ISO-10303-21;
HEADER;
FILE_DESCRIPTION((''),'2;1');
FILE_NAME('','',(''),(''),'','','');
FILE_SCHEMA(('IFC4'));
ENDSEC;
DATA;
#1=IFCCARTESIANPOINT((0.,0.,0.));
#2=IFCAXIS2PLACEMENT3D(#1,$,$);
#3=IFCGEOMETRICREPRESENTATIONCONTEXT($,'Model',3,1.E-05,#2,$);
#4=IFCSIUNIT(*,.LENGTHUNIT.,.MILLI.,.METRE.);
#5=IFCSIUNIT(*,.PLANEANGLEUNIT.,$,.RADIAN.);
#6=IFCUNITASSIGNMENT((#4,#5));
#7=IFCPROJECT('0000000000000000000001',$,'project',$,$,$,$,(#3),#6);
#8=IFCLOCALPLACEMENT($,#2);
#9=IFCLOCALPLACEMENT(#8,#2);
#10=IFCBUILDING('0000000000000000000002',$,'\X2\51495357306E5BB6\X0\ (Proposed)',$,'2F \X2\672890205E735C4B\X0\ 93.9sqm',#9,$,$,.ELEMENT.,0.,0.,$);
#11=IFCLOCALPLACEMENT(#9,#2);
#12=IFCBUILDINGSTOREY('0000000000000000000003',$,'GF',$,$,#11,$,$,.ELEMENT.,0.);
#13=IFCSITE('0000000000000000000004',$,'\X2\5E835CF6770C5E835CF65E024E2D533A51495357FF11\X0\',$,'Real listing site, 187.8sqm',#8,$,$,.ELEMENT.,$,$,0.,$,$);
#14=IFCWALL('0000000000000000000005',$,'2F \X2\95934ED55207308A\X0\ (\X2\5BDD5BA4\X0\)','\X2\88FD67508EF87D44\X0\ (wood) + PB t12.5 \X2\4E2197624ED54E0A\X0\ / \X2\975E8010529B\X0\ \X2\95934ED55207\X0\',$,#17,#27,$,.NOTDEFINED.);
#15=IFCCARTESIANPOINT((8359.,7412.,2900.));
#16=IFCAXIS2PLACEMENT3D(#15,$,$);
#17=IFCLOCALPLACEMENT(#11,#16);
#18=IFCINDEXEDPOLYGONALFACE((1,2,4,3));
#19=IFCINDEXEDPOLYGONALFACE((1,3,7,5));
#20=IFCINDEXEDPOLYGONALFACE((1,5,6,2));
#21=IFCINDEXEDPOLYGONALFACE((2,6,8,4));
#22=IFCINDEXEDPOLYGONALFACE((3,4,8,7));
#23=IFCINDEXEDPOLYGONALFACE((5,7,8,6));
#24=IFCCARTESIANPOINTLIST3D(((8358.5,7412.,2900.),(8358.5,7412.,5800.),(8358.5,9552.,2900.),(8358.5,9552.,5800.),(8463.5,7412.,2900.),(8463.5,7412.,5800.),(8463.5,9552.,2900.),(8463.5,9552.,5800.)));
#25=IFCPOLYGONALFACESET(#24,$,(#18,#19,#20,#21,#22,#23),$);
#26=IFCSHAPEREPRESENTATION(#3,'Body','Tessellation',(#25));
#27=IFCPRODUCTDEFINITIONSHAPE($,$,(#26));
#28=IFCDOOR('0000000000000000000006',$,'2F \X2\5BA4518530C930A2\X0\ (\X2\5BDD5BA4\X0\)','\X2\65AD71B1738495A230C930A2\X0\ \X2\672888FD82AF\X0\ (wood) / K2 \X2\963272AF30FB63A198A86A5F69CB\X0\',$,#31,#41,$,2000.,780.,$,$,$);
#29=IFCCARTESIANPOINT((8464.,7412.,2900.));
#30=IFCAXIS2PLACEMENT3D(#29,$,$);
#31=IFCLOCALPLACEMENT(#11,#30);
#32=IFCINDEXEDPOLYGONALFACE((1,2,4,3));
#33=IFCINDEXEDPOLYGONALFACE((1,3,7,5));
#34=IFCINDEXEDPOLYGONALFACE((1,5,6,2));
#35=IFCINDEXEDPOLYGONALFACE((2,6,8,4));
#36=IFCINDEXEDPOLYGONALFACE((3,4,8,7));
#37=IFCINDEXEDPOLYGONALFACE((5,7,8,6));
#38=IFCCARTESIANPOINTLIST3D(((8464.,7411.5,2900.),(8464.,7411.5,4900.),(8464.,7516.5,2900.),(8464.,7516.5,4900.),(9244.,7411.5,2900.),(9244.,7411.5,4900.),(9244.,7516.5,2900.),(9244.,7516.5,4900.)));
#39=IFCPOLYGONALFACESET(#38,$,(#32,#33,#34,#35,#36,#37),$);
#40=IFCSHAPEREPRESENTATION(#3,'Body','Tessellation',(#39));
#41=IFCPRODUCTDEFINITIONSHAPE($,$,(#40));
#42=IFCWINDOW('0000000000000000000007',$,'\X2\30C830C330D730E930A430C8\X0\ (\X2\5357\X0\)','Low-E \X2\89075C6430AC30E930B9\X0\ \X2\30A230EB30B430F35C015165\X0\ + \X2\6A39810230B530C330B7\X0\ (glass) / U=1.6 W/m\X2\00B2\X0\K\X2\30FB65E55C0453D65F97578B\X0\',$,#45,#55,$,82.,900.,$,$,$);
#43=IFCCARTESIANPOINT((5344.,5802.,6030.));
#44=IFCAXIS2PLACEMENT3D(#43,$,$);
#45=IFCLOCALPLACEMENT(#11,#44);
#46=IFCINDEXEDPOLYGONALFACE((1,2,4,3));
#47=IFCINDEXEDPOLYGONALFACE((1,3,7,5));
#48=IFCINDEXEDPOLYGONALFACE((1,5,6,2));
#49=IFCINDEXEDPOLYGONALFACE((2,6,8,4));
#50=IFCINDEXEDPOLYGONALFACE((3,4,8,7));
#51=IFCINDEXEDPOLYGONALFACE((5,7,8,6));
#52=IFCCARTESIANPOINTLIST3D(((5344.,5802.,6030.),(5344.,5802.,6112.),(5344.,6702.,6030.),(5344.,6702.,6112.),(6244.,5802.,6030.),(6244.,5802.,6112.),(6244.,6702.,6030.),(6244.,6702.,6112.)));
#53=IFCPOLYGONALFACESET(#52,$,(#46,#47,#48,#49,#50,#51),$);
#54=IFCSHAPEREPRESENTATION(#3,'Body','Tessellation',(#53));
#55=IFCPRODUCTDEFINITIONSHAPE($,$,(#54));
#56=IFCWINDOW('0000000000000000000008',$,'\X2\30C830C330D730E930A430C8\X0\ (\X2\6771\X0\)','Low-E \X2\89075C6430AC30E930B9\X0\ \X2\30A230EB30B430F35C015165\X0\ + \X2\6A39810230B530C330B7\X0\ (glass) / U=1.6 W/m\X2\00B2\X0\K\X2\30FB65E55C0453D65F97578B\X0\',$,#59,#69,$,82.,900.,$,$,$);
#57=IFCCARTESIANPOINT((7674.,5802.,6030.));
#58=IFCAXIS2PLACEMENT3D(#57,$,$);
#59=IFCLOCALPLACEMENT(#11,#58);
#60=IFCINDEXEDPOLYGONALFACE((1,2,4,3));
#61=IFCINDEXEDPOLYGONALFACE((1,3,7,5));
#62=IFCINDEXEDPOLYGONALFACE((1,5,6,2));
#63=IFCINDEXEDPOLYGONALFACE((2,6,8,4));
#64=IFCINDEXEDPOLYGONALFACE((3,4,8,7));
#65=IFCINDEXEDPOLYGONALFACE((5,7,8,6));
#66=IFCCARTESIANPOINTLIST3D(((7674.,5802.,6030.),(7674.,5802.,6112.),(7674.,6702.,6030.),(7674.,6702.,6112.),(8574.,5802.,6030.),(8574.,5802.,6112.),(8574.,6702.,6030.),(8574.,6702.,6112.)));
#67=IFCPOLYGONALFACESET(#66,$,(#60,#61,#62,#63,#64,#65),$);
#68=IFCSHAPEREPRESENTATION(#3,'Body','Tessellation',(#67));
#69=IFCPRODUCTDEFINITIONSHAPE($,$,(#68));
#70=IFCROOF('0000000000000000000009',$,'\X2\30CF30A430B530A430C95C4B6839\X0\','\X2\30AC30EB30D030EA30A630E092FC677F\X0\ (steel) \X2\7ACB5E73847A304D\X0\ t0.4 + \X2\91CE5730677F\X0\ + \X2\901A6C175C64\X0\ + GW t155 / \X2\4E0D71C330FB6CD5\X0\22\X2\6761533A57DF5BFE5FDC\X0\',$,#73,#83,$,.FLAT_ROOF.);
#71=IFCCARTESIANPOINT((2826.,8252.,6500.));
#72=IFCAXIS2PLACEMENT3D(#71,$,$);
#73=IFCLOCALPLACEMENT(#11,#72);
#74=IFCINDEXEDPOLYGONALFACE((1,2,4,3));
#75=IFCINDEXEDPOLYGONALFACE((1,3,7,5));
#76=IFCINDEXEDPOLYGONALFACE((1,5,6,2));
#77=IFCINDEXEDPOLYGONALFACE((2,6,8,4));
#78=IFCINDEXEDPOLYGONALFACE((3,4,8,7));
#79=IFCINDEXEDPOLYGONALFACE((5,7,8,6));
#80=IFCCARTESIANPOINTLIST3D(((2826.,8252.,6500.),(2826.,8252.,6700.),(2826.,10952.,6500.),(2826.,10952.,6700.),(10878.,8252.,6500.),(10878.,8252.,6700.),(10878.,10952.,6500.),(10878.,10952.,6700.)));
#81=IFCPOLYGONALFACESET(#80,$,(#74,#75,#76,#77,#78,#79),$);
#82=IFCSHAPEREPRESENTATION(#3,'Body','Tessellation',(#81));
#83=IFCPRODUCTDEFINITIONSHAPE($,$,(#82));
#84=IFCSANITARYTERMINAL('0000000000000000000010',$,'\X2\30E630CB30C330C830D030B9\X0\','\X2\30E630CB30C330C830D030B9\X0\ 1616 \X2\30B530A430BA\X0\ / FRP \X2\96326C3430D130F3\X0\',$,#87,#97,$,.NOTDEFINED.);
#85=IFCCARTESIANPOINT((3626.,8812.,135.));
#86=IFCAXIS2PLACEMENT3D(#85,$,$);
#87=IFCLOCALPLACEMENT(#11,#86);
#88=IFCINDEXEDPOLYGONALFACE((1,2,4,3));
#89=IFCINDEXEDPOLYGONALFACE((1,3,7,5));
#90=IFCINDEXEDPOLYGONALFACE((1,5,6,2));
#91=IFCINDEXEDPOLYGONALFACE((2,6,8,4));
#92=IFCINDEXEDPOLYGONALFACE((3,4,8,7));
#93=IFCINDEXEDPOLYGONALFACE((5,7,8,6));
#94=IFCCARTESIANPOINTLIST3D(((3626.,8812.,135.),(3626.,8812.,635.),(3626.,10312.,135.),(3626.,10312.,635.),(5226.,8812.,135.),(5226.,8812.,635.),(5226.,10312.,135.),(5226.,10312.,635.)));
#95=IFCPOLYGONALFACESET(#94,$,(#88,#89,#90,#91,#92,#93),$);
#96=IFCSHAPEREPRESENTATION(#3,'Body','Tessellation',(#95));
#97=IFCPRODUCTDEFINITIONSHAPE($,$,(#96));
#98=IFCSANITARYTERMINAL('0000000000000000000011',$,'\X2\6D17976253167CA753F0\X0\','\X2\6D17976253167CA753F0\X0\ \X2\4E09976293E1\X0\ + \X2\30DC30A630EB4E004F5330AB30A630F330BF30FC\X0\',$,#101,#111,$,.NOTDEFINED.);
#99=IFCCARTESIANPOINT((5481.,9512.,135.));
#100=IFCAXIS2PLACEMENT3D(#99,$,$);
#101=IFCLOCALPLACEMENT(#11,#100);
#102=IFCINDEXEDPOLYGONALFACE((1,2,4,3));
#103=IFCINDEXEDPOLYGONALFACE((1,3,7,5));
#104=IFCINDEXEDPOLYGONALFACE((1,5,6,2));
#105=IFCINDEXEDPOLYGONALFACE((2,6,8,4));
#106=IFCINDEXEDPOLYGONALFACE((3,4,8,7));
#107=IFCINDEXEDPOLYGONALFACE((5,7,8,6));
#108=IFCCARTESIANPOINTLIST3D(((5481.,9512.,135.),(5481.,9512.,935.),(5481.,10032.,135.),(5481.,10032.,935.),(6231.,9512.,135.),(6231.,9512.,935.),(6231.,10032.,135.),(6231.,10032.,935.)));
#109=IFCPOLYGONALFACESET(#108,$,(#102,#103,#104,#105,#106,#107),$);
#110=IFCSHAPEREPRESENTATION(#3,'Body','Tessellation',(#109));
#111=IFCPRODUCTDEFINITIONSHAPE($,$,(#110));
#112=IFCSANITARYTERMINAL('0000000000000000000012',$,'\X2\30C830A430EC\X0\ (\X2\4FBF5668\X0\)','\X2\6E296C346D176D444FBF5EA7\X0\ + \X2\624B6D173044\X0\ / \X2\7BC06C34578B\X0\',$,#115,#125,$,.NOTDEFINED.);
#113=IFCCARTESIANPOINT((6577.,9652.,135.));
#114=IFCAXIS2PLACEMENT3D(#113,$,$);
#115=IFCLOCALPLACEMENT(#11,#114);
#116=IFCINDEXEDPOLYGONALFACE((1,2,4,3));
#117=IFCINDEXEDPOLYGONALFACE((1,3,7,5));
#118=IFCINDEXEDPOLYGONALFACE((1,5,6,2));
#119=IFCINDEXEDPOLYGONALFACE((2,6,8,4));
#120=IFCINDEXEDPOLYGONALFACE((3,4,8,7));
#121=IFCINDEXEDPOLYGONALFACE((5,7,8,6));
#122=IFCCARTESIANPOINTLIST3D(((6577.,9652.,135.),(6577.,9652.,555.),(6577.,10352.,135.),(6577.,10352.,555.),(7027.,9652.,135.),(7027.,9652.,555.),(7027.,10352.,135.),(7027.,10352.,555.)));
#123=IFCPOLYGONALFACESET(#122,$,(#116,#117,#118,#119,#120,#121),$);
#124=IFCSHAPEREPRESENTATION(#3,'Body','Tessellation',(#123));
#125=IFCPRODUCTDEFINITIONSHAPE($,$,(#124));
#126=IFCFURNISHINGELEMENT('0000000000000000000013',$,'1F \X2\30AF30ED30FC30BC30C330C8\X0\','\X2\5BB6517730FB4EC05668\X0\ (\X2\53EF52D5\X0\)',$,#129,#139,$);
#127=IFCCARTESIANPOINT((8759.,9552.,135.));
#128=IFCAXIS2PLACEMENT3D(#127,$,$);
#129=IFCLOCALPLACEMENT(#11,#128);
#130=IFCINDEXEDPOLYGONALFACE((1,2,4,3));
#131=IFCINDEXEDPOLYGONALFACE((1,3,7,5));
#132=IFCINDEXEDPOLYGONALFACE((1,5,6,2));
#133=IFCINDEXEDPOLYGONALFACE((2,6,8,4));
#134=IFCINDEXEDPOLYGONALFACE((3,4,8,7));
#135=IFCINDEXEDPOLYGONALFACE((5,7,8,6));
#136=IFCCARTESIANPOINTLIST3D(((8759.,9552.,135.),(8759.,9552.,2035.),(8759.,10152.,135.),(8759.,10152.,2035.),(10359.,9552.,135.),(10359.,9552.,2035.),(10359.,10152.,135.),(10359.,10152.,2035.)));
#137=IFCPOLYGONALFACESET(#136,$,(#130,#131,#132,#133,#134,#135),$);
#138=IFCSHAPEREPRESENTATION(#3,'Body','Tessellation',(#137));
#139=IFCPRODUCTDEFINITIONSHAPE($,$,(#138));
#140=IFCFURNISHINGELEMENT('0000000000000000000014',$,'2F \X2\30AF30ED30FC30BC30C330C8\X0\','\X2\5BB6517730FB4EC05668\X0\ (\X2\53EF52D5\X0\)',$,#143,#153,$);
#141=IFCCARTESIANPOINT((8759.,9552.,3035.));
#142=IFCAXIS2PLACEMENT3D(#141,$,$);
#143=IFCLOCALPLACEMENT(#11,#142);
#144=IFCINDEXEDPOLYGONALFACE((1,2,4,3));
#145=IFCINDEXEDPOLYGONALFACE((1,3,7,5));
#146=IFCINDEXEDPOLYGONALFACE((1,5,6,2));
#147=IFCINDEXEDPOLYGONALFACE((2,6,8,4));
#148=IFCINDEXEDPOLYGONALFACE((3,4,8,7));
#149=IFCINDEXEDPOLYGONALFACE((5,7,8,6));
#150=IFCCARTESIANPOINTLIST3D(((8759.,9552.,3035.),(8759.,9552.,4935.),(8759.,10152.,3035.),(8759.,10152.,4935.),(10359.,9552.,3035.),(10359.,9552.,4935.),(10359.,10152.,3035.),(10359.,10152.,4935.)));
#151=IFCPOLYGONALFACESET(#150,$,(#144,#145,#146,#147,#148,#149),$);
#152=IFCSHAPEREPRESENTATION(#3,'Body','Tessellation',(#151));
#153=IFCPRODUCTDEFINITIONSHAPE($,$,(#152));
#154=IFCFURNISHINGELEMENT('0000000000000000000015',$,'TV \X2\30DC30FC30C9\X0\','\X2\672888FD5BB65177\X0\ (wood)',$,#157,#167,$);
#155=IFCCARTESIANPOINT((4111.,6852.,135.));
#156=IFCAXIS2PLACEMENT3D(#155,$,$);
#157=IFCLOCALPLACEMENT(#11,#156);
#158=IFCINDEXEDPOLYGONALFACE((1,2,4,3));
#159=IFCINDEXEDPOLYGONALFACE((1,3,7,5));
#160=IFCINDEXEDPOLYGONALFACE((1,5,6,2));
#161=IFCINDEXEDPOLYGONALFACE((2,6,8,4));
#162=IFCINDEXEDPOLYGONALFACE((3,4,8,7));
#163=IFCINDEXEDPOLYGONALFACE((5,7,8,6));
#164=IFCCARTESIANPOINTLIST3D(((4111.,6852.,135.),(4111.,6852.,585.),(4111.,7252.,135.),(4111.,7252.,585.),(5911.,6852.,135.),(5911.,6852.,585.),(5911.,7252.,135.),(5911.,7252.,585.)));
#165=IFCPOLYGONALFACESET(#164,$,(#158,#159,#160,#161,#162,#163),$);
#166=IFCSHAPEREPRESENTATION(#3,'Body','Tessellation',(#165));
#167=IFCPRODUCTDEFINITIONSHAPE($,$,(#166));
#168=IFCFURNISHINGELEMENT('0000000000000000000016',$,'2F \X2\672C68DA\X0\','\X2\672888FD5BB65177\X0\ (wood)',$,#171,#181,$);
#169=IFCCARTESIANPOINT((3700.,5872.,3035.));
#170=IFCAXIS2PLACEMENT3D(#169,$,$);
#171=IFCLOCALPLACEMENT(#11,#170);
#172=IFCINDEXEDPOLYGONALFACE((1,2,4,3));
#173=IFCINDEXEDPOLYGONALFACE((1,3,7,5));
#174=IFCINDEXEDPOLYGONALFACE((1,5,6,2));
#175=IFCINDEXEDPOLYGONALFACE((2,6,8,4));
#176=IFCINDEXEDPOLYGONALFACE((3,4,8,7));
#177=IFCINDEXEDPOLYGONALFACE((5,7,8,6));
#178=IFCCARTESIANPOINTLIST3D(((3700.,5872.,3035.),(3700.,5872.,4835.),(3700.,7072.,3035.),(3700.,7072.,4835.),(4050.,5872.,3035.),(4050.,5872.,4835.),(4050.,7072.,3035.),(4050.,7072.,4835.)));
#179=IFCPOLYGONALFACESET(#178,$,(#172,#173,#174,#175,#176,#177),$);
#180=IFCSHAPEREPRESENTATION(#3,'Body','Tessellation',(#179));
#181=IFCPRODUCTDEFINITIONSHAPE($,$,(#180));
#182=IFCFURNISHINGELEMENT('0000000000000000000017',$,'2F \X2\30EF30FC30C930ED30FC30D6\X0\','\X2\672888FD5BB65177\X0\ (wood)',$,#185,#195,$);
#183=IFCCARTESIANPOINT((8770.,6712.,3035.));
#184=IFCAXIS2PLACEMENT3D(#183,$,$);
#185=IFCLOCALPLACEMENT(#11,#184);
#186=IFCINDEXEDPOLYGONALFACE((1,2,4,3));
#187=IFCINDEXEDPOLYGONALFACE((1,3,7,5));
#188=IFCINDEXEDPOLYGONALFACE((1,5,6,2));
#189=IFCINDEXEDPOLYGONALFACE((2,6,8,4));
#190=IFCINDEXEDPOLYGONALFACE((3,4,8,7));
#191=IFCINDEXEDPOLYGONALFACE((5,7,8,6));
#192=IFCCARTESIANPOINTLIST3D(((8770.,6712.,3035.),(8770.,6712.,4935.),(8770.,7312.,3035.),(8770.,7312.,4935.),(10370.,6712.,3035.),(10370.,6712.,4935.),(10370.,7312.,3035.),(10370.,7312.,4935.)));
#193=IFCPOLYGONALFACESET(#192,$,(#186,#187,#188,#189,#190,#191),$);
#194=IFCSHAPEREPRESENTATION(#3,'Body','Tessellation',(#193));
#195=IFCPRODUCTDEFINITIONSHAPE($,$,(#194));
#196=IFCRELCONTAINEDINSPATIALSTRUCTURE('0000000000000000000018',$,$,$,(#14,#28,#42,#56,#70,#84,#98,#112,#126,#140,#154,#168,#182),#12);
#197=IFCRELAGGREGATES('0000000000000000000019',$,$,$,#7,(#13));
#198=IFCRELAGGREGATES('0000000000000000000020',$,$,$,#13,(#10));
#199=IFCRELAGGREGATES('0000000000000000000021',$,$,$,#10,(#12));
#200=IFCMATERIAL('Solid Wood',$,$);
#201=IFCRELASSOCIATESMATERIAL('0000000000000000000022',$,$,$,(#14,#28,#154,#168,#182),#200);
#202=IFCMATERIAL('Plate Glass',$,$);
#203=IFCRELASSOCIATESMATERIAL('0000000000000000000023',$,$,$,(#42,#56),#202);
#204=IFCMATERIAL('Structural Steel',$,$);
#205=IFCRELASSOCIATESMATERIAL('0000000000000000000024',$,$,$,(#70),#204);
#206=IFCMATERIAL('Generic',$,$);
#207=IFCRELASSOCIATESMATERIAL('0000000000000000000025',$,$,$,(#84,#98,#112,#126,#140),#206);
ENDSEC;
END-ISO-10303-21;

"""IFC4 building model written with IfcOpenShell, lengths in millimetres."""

from ifc_helpers import new_model, si_unit, frame, frame_2d, origin, place, context, project, spatial, rectangle, extrude, material, element, save


model = new_model("IFC4")

# Units and contexts
model_context = context("Model", 3, precision=1e-05, world=origin())
ifc_project = project(units=[si_unit("LENGTHUNIT", "METRE", prefix="MILLI"), si_unit("PLANEANGLEUNIT", "RADIAN")], contexts=[model_context])

# Site, building, storey
site_placement = place(None, origin())
site = spatial("IfcSite", under=ifc_project, at=site_placement, Name="広島県広島市中区光南１", ObjectType="Real listing site, 187.8sqm", CompositionType="ELEMENT", RefElevation=0.0)
building_placement = place(site_placement, origin())
building = spatial("IfcBuilding", under=site, at=building_placement, Name="光南の家 (Proposed)", ObjectType="2F 木造平屋 93.9sqm", CompositionType="ELEMENT", ElevationOfRefHeight=0.0, ElevationOfTerrain=0.0)
storey_placement = place(building_placement, origin())
storey = spatial("IfcBuildingStorey", under=building, at=storey_placement, Name="GF", CompositionType="ELEMENT", Elevation=0.0)

# Shared definitions
ifc_material_1 = material(Name="Solid Wood")
ifc_material_2 = material(Name="Plate Glass")

# Wall
wall_1_placement = place(storey_placement, frame((8359.0, 7412.0, 2900.0)))
element("IfcWall", 1, at=wall_1_placement, inside=storey, material=ifc_material_1, Name="2F 間仕切り (寝室)", Description="製材軸組 (wood) + PB t12.5 両面仕上 / 非耐力 間仕切", PredefinedType="NOTDEFINED", context=model_context, shape_type="SweptSolid", body=[
    extrude(rectangle(XDim=105.0, YDim=2140.0, at=frame_2d((52.0, 1070.0))), frame((8359.0, 7412.0, 2900.0)), (0.0, 0.0, 1.0), 2900.0),
])

# Door
door_1_placement = place(storey_placement, frame((8464.0, 7412.0, 2900.0)))
element("IfcDoor", 2, at=door_1_placement, inside=storey, material=ifc_material_1, Name="2F 室内ドア (寝室)", Description="断熱玄関ドア 木製芯 (wood) / K2 防犯・採風機構", OverallHeight=2000.0, OverallWidth=780.0, context=model_context, shape_type="SweptSolid", body=[
    extrude(rectangle(XDim=780.0, YDim=105.0, at=frame_2d((390.0, 52.0))), frame((8464.0, 7412.0, 2900.0)), (0.0, 0.0, 1.0), 2000.0),
])

# Windows
window_1_placement = place(storey_placement, frame((5344.0, 5802.0, 6030.0)))
element("IfcWindow", 3, at=window_1_placement, inside=storey, material=ifc_material_2, Name="トップライト (南)", Description="Low-E 複層ガラス アルゴン封入 + 樹脂サッシ (glass) / U=1.6 W/m²K・日射取得型", OverallHeight=82.0, OverallWidth=900.0, context=model_context, shape_type="SweptSolid", body=[
    extrude(rectangle(XDim=900.0, YDim=900.0, at=frame_2d((450.0, 450.0))), frame((5344.0, 5802.0, 6030.0)), (0.0, 0.0, 1.0), 82.0),
])
window_2_placement = place(storey_placement, frame((7674.0, 5802.0, 6030.0)))
element("IfcWindow", 4, at=window_2_placement, inside=storey, material=ifc_material_2, Name="トップライト (東)", Description="Low-E 複層ガラス アルゴン封入 + 樹脂サッシ (glass) / U=1.6 W/m²K・日射取得型", OverallHeight=82.0, OverallWidth=900.0, context=model_context, shape_type="SweptSolid", body=[
    extrude(rectangle(XDim=900.0, YDim=900.0, at=frame_2d((450.0, 450.0))), frame((7674.0, 5802.0, 6030.0)), (0.0, 0.0, 1.0), 82.0),
])

# Roof
ifc_material_3 = material(Name="Structural Steel")
roof_placement = place(storey_placement, frame((2826.0, 8252.0, 6500.0)))
element("IfcRoof", 5, at=roof_placement, inside=storey, material=ifc_material_3, Name="ハイサイド屋根", Description="ガルバリウム鋼板 (steel) 立平葺き t0.4 + 野地板 + 通気層 + GW t155 / 不燃・法22条区域対応", PredefinedType="FLAT_ROOF", context=model_context, shape_type="SweptSolid", body=[
    extrude(rectangle(XDim=8052.0, YDim=2700.0, at=frame_2d((4026.0, 1350.0))), frame((2826.0, 8252.0, 6500.0)), (0.0, 0.0, 1.0), 200.0),
])

# Sanitary terminals
ifc_material_4 = material(Name="Generic")
sanitary_terminal_1_placement = place(storey_placement, frame((3626.0, 8812.0, 135.0)))
element("IfcSanitaryTerminal", 6, at=sanitary_terminal_1_placement, inside=storey, material=ifc_material_4, Name="ユニットバス", Description="ユニットバス 1616 サイズ / FRP 防水パン", PredefinedType="NOTDEFINED", context=model_context, shape_type="SweptSolid", body=[
    extrude(rectangle(XDim=1600.0, YDim=1500.0, at=frame_2d((800.0, 750.0))), frame((3626.0, 8812.0, 135.0)), (0.0, 0.0, 1.0), 500.0),
])
sanitary_terminal_2_placement = place(storey_placement, frame((5481.0, 9512.0, 135.0)))
element("IfcSanitaryTerminal", 7, at=sanitary_terminal_2_placement, inside=storey, material=ifc_material_4, Name="洗面化粧台", Description="洗面化粧台 三面鏡 + ボウル一体カウンター", PredefinedType="NOTDEFINED", context=model_context, shape_type="SweptSolid", body=[
    extrude(rectangle(XDim=750.0, YDim=520.0, at=frame_2d((375.0, 260.0))), frame((5481.0, 9512.0, 135.0)), (0.0, 0.0, 1.0), 800.0),
])
sanitary_terminal_3_placement = place(storey_placement, frame((6577.0, 9652.0, 135.0)))
element("IfcSanitaryTerminal", 8, at=sanitary_terminal_3_placement, inside=storey, material=ifc_material_4, Name="トイレ (便器)", Description="温水洗浄便座 + 手洗い / 節水型", PredefinedType="NOTDEFINED", context=model_context, shape_type="SweptSolid", body=[
    extrude(rectangle(XDim=450.0, YDim=700.0, at=frame_2d((225.0, 350.0))), frame((6577.0, 9652.0, 135.0)), (0.0, 0.0, 1.0), 420.0),
])

# Furnishing elements
furnishing_1_placement = place(storey_placement, frame((8759.0, 9552.0, 135.0)))
element("IfcFurnishingElement", 9, at=furnishing_1_placement, inside=storey, material=ifc_material_4, Name="1F クローゼット", Description="家具・什器 (可動)", context=model_context, shape_type="SweptSolid", body=[
    extrude(rectangle(XDim=1600.0, YDim=600.0, at=frame_2d((800.0, 300.0))), frame((8759.0, 9552.0, 135.0)), (0.0, 0.0, 1.0), 1900.0),
])
furnishing_2_placement = place(storey_placement, frame((8759.0, 9552.0, 3035.0)))
element("IfcFurnishingElement", 10, at=furnishing_2_placement, inside=storey, material=ifc_material_4, Name="2F クローゼット", Description="家具・什器 (可動)", context=model_context, shape_type="SweptSolid", body=[
    extrude(rectangle(XDim=1600.0, YDim=600.0, at=frame_2d((800.0, 300.0))), frame((8759.0, 9552.0, 3035.0)), (0.0, 0.0, 1.0), 1900.0),
])
furnishing_3_placement = place(storey_placement, frame((4111.0, 6852.0, 135.0)))
element("IfcFurnishingElement", 11, at=furnishing_3_placement, inside=storey, material=ifc_material_1, Name="TV ボード", Description="木製家具 (wood)", context=model_context, shape_type="SweptSolid", body=[
    extrude(rectangle(XDim=1800.0, YDim=400.0, at=frame_2d((900.0, 200.0))), frame((4111.0, 6852.0, 135.0)), (0.0, 0.0, 1.0), 450.0),
])
furnishing_4_placement = place(storey_placement, frame((3700.0, 5872.0, 3035.0)))
element("IfcFurnishingElement", 12, at=furnishing_4_placement, inside=storey, material=ifc_material_1, Name="2F 本棚", Description="木製家具 (wood)", context=model_context, shape_type="SweptSolid", body=[
    extrude(rectangle(XDim=350.0, YDim=1200.0, at=frame_2d((175.0, 600.0))), frame((3700.0, 5872.0, 3035.0)), (0.0, 0.0, 1.0), 1800.0),
])
furnishing_5_placement = place(storey_placement, frame((8770.0, 6712.0, 3035.0)))
element("IfcFurnishingElement", 13, at=furnishing_5_placement, inside=storey, material=ifc_material_1, Name="2F ワードローブ", Description="木製家具 (wood)", context=model_context, shape_type="SweptSolid", body=[
    extrude(rectangle(XDim=1600.0, YDim=600.0, at=frame_2d((800.0, 300.0))), frame((8770.0, 6712.0, 3035.0)), (0.0, 0.0, 1.0), 1900.0),
])

save(model, "model.ifc")
